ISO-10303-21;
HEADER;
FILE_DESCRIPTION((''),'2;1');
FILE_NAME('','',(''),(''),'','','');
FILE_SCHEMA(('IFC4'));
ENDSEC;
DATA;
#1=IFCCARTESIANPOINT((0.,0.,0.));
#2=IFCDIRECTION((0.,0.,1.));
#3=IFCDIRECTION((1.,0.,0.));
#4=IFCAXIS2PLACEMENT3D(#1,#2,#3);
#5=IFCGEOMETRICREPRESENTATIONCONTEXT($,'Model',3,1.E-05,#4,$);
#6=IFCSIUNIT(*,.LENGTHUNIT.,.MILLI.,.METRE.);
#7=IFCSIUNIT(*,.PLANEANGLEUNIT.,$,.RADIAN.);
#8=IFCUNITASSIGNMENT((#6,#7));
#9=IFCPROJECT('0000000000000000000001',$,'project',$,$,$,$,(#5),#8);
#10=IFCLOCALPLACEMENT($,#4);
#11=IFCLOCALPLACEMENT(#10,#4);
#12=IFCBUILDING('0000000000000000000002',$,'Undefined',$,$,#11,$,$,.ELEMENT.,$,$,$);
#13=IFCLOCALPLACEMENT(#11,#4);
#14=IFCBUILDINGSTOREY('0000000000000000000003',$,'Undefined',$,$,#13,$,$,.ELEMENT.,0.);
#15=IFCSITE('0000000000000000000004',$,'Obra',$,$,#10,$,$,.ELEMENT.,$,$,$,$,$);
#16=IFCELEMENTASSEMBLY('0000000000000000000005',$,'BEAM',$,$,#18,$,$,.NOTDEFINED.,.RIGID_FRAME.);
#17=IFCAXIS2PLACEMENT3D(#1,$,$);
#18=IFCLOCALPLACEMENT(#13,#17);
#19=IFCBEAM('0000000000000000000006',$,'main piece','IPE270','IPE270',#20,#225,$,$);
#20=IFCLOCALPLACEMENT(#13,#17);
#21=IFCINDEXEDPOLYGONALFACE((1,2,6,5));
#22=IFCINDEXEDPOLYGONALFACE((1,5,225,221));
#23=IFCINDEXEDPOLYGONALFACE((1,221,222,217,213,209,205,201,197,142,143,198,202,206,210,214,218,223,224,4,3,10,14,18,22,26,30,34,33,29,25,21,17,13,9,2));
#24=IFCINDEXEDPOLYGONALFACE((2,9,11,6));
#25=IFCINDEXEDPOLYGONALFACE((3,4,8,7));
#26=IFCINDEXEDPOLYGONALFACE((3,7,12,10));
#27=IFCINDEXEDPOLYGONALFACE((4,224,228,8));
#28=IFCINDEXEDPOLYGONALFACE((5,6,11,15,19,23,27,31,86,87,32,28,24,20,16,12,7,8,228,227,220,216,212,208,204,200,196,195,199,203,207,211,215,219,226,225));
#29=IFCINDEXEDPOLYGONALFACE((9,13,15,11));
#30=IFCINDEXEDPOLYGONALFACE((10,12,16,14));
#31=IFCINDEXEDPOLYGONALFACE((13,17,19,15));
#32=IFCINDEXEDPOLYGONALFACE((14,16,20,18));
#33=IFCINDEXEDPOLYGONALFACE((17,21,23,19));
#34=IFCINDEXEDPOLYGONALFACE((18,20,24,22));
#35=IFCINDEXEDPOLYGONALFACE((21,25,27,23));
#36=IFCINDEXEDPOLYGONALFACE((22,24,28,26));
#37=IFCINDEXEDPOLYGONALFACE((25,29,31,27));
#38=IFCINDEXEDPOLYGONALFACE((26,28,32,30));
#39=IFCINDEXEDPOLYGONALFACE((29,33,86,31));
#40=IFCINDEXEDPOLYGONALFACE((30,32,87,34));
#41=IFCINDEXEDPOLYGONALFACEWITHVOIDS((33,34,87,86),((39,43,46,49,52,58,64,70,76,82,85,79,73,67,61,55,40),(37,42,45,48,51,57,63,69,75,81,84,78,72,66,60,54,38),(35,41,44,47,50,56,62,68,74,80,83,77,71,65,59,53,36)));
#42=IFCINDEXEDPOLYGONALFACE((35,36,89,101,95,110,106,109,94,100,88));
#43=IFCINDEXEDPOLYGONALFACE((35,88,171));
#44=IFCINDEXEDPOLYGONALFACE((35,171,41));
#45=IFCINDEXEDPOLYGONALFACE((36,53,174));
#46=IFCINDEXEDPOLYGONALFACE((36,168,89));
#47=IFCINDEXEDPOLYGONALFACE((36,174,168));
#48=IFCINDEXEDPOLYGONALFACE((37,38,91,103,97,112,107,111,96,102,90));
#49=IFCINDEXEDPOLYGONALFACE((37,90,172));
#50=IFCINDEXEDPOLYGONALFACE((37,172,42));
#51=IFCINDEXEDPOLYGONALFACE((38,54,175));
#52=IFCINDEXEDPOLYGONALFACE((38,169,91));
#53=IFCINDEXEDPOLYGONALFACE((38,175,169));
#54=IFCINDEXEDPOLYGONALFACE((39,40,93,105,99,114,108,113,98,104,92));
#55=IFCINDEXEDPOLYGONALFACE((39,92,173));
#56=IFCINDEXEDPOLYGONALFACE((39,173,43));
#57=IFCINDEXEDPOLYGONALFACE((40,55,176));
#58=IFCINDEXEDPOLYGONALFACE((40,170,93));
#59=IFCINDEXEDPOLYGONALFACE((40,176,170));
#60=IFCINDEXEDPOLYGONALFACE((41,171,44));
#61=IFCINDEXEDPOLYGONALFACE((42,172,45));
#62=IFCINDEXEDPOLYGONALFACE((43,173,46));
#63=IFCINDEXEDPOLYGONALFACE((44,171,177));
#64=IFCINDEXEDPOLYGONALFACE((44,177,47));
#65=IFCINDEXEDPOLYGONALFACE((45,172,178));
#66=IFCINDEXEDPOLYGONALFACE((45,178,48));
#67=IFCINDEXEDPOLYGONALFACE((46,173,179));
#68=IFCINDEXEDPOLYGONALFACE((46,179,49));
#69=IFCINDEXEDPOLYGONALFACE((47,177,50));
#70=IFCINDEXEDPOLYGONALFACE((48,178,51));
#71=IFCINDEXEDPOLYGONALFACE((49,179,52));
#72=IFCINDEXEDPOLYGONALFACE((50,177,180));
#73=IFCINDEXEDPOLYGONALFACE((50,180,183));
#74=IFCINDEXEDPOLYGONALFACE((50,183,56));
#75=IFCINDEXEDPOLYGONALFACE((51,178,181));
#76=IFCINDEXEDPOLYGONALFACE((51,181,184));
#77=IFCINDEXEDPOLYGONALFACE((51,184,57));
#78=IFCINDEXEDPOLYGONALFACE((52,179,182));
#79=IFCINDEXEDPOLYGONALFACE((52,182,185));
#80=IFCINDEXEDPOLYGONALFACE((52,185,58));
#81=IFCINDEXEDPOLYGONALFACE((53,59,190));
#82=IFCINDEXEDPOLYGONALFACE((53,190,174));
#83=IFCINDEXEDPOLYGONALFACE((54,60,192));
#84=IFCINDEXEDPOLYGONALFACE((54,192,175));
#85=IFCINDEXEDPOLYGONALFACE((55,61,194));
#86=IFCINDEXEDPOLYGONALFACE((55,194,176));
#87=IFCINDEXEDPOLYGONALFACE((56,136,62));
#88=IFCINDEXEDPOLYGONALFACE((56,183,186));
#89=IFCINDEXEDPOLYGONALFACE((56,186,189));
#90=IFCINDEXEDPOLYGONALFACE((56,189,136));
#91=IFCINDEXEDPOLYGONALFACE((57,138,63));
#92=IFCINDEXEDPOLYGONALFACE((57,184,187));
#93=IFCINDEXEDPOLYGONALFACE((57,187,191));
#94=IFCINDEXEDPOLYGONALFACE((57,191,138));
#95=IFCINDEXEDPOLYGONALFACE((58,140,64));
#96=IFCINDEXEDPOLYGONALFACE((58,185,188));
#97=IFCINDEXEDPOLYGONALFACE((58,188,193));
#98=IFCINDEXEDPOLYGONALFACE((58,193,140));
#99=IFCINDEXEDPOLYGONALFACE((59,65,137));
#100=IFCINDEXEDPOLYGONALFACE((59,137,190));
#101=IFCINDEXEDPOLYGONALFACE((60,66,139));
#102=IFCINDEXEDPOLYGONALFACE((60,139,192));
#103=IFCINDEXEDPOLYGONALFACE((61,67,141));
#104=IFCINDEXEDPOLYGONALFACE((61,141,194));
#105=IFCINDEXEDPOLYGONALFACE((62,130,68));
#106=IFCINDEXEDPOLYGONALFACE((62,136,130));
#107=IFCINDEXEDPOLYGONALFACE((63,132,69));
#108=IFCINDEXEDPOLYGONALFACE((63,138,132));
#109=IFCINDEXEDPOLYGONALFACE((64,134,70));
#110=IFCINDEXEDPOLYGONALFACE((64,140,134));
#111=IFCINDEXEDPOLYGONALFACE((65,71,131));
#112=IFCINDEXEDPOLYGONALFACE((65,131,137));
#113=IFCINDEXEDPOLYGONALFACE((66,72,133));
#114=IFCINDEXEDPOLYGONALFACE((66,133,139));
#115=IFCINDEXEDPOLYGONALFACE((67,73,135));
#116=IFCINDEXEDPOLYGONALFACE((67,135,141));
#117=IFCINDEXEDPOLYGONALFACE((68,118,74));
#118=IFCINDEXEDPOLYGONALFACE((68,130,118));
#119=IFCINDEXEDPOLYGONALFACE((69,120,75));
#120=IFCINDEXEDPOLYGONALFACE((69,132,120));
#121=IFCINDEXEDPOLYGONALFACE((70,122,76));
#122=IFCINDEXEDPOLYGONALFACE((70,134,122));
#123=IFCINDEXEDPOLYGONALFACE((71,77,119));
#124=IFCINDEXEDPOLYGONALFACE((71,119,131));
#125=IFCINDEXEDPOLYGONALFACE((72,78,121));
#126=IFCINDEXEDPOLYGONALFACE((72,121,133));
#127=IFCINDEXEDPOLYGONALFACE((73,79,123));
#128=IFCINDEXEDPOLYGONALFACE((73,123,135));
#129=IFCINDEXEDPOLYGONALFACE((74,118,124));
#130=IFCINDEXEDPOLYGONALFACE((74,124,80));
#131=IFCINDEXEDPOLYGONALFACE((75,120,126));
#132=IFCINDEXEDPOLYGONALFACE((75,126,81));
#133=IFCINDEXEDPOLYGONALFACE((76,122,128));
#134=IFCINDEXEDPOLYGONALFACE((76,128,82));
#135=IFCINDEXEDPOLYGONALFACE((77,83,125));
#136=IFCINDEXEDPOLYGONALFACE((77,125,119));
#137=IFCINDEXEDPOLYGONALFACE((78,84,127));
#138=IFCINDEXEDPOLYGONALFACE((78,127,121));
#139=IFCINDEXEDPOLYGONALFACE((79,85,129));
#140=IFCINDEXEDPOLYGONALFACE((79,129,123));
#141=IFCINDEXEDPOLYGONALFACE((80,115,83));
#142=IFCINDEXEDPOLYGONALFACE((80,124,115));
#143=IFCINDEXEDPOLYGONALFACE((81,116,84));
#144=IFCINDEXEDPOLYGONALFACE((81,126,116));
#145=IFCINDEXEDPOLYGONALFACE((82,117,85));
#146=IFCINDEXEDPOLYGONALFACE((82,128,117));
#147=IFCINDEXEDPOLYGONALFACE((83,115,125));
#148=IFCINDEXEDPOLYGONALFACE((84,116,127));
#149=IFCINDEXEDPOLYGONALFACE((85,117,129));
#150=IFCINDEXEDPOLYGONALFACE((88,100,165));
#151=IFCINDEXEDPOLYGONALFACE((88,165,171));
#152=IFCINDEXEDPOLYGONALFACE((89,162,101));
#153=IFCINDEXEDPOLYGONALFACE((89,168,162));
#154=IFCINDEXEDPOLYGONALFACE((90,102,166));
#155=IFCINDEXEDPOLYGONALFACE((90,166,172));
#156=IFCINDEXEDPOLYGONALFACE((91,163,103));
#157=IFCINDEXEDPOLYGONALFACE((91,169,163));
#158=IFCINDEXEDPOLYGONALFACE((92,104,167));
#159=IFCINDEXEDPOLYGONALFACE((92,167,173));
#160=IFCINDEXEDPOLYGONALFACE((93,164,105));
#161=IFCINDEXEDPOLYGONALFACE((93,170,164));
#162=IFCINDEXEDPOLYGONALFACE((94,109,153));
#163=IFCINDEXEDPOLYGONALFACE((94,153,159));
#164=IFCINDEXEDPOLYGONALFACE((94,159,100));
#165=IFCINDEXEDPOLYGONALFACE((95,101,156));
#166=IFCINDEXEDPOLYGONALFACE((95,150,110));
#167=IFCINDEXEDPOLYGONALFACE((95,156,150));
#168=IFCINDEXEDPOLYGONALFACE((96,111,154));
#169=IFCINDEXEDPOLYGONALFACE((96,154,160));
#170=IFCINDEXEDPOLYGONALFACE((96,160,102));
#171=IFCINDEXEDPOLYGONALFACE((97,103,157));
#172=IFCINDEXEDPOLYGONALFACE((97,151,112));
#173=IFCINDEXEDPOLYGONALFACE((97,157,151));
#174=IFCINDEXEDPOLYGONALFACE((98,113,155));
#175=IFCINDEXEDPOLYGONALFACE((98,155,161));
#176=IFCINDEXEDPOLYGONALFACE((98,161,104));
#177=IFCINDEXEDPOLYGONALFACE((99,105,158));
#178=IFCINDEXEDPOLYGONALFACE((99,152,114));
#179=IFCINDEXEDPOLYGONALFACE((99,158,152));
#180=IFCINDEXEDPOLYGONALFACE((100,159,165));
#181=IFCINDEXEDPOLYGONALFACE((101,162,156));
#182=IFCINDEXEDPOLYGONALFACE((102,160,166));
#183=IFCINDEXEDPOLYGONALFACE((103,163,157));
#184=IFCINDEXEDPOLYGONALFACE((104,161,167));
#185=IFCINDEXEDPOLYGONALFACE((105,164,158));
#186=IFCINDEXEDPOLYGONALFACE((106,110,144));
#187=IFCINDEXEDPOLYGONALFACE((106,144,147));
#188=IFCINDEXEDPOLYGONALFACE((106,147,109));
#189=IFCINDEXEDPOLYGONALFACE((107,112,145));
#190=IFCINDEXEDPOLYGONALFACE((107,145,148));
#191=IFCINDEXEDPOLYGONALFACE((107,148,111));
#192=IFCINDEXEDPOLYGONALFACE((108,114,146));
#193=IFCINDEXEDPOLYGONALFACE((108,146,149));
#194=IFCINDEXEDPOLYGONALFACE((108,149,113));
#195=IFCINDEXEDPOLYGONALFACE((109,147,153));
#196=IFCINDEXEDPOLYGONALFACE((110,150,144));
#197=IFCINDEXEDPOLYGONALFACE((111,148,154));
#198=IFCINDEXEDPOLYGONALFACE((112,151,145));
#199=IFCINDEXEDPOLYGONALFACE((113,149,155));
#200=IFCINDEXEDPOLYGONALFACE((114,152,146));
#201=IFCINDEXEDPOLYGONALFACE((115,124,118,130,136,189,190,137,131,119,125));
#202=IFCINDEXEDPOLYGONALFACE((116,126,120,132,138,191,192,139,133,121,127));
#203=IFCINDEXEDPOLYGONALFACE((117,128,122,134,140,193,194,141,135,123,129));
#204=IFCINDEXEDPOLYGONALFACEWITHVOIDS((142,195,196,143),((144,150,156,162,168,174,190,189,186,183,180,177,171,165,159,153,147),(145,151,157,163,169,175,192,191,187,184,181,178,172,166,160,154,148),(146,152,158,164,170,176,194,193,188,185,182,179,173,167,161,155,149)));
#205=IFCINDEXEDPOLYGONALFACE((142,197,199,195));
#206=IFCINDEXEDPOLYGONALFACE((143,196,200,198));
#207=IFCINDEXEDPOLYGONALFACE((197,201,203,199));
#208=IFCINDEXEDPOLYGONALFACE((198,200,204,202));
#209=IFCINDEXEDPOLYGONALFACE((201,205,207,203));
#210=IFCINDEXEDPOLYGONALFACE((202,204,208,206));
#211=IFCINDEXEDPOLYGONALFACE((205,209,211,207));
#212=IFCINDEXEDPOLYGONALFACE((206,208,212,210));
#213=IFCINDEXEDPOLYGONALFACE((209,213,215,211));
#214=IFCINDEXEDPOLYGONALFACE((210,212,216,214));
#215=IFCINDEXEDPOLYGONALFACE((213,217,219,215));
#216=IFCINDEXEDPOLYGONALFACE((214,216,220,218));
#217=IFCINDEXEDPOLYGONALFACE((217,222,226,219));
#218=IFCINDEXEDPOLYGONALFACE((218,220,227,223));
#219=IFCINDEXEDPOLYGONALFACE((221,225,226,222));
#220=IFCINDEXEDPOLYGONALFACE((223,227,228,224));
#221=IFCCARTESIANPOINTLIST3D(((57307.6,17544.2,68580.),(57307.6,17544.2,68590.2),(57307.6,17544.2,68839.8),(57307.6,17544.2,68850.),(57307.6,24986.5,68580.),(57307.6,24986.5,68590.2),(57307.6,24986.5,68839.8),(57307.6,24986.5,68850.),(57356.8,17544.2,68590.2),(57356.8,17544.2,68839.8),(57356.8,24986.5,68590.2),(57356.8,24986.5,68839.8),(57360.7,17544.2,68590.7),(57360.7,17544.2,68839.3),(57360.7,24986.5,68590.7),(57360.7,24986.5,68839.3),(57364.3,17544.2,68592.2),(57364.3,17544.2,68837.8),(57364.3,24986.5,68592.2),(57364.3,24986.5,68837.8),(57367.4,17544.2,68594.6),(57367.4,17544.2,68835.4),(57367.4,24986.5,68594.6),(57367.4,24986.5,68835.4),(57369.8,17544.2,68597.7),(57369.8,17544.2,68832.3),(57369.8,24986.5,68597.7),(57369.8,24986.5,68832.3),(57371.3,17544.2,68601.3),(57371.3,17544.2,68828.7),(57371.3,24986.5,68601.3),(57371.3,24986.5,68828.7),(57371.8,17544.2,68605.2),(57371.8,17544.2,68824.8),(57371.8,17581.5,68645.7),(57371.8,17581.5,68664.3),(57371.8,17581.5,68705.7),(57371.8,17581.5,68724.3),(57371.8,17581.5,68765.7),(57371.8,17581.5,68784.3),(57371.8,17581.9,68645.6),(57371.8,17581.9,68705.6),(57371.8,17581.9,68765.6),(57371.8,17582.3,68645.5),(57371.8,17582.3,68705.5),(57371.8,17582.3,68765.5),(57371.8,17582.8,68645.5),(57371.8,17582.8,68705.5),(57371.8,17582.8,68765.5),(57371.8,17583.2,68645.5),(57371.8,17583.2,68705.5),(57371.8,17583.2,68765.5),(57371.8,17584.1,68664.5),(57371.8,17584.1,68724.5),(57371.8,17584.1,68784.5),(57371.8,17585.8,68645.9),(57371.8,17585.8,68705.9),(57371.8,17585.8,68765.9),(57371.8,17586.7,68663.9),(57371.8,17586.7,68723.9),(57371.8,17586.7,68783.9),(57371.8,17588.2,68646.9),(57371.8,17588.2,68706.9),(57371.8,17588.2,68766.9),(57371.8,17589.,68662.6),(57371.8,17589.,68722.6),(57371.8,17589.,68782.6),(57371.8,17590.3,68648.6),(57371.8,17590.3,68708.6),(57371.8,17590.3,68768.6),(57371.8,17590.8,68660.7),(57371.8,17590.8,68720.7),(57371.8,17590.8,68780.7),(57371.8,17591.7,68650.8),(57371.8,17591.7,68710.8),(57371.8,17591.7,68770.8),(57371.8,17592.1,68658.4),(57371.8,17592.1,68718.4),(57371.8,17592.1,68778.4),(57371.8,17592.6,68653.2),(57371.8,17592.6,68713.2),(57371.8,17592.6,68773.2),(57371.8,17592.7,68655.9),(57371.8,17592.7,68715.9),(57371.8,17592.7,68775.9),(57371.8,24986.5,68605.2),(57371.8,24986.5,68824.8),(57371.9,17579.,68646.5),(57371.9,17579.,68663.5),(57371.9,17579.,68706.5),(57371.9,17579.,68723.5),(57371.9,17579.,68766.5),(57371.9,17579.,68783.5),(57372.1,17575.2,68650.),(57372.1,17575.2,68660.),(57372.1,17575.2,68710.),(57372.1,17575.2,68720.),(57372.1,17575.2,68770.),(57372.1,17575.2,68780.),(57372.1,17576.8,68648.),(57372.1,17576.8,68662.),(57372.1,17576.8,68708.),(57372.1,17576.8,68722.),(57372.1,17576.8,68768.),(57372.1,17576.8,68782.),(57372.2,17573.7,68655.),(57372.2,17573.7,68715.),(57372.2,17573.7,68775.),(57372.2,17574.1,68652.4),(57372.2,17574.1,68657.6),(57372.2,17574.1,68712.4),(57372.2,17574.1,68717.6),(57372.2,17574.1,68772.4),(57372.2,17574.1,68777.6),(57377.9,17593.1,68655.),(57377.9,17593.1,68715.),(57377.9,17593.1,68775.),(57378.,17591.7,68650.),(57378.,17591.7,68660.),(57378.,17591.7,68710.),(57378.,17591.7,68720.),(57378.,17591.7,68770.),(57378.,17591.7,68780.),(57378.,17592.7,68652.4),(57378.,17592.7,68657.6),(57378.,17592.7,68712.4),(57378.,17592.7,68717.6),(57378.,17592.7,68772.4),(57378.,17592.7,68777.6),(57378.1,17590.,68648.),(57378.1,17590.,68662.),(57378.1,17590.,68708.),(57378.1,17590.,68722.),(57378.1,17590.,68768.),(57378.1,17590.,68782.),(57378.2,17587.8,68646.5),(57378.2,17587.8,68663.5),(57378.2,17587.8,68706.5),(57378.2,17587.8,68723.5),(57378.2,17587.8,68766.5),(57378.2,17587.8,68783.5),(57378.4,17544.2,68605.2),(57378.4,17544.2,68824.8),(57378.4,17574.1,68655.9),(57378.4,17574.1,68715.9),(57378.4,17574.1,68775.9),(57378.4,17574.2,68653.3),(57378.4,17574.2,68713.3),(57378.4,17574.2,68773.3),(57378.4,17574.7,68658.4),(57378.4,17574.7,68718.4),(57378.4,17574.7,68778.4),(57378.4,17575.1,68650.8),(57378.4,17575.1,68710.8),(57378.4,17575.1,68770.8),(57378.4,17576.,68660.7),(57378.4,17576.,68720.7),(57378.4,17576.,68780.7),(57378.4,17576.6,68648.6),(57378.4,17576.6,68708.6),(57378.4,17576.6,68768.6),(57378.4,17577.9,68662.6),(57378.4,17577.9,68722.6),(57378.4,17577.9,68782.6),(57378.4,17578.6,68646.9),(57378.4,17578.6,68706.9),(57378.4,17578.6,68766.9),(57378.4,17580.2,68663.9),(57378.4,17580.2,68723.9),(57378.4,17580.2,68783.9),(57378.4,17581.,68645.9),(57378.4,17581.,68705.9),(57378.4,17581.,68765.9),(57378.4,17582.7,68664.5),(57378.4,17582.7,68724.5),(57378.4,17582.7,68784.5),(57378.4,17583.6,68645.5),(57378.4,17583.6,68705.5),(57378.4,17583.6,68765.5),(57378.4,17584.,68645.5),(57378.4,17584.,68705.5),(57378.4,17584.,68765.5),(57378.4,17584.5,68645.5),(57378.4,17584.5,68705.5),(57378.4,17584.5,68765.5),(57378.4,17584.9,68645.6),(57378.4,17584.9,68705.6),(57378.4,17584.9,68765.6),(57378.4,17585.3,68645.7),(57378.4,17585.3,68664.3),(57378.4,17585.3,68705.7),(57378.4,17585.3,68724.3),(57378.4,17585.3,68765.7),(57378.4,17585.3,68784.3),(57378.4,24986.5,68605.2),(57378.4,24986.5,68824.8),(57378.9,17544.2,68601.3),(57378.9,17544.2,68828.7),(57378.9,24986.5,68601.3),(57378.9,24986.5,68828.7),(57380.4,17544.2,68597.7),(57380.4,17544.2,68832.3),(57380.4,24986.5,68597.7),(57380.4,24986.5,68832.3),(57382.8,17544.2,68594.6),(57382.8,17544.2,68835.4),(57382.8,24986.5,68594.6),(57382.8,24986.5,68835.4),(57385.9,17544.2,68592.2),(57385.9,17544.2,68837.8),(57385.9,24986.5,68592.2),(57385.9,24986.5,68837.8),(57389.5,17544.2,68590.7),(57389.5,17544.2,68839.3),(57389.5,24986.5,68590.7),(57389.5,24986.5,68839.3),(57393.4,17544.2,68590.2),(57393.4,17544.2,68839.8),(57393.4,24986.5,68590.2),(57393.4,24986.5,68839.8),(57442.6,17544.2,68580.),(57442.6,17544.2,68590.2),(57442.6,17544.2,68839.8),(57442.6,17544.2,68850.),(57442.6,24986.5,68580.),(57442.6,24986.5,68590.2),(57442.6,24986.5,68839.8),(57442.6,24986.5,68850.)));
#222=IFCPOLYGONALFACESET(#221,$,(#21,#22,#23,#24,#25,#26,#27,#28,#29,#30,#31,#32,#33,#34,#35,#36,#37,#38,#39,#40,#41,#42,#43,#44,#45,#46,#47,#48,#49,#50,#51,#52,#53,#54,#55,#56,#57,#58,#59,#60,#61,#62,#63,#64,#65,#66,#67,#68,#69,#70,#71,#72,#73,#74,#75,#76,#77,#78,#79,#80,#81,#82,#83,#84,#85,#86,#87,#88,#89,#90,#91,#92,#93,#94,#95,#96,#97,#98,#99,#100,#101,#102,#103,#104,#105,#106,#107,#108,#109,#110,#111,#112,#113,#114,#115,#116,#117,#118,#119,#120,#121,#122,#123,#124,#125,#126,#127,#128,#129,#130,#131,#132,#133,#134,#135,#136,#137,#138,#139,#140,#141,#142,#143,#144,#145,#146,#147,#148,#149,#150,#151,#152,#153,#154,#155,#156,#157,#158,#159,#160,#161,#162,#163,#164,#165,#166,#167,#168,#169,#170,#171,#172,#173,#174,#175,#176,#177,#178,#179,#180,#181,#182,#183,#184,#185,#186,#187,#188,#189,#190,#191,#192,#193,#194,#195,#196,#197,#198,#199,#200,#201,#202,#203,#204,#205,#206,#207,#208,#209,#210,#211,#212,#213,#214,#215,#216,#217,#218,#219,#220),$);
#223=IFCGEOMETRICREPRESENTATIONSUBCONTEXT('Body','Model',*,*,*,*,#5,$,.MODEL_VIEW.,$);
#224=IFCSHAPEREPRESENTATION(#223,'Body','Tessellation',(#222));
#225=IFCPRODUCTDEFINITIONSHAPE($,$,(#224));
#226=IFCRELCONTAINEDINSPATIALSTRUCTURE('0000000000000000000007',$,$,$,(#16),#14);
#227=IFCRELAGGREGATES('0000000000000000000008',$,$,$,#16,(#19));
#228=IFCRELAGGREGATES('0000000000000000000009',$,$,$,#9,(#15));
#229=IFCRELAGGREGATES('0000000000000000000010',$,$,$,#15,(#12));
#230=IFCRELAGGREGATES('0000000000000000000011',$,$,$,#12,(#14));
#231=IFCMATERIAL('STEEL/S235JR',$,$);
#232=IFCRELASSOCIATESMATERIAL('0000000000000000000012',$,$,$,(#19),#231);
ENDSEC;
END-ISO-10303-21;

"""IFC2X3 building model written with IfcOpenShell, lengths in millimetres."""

from ifc_helpers import new_model, si_unit, frame, origin_with_axes, origin_2d_with_axis, place, context, subcontext, project, spatial, circle, i_section, extrude, clip, halfspace, source, transform, mapped, material, element, aggregate, save


model = new_model("IFC2X3")

# Units and contexts
model_context = context("Model", 3, precision=1e-05, world=origin_with_axes())
body_context = subcontext(model_context, "Body", "Model", "MODEL_VIEW")
ifc_project = project(units=[si_unit("LENGTHUNIT", "METRE", prefix="MILLI"), si_unit("PLANEANGLEUNIT", "RADIAN")], contexts=[model_context])

# Site, building, storey
site_placement = place(None, origin_with_axes())
site = spatial("IfcSite", under=ifc_project, at=site_placement, Name="Obra", CompositionType="ELEMENT")
building_placement = place(site_placement, origin_with_axes())
building = spatial("IfcBuilding", under=site, at=building_placement, Name="Undefined", CompositionType="ELEMENT")
storey_placement = place(building_placement, origin_with_axes())
storey = spatial("IfcBuildingStorey", under=building, at=storey_placement, Name="Undefined", CompositionType="ELEMENT", Elevation=0.0)

# Shared definitions
ifc_material_1 = material(Name="STEEL/S235JR")

# Element assembly, beam, opening
assembly_1_placement = place(storey_placement, origin_with_axes())
assembly_1 = element("IfcElementAssembly", 1, at=assembly_1_placement, inside=storey, Name="BEAM", AssemblyPlace="NOTDEFINED", PredefinedType="RIGID_FRAME")
beam_1_placement = place(assembly_1_placement, frame((57375.1, 17544.2, 68715.0), z_axis=(0.0, 0.0, 1.0), x_axis=(0.0, 1.0, 0.0)))
beam_1 = element("IfcBeam", 2, at=beam_1_placement, material=ifc_material_1, Name="main piece", Description="IPE270", ObjectType="IPE270", context=body_context, shape_type="Clipping", body=[
    clip(extrude(i_section(OverallWidth=135.0, OverallDepth=270.0, WebThickness=6.6, FlangeThickness=10.2, FilletRadius=15.0, at=origin_2d_with_axis()), frame((7442.3, 0.0, 0.0), z_axis=(-1.0, 0.0, 0.0), x_axis=(0.0, -1.0, 0.0)), (0.0, 0.0, 1.0), 7442.4), halfspace(frame((-15.5, 89.1, -120.0), z_axis=(-0.998367, -0.057127, 0.0), x_axis=(0.0, 0.0, 1.0)), False)),
])
shared_shape_1 = source(origin_with_axes(), body_context, "Body", "SweptSolid", [
    extrude(circle(Radius=9.5, at=origin_2d_with_axis()), frame((0.0, -35.4, 0.0), z_axis=(0.0, 1.0, 0.0), x_axis=(1.0, 0.0, 0.0)), (0.0, 0.0, 1.0), 6.8),
])
opening_1_placement = place(assembly_1_placement, frame((57346.0, 17531.7, 68835.0), z_axis=(-0.057107, 0.998368, 0.0), x_axis=(0.0, 0.0, -1.0)))
element("IfcOpeningElement", 3, at=opening_1_placement, cuts=beam_1, ObjectType="Opening", context=body_context, shape_type="MappedRepresentation", body=[
    mapped(shared_shape_1, transform((60.0, 0.0, 50.0))),
    mapped(shared_shape_1, transform((120.0, 0.0, 50.0))),
    mapped(shared_shape_1, transform((180.0, 0.0, 50.0))),
])
aggregate(assembly_1, [beam_1])

save(model, "model.ifc")
